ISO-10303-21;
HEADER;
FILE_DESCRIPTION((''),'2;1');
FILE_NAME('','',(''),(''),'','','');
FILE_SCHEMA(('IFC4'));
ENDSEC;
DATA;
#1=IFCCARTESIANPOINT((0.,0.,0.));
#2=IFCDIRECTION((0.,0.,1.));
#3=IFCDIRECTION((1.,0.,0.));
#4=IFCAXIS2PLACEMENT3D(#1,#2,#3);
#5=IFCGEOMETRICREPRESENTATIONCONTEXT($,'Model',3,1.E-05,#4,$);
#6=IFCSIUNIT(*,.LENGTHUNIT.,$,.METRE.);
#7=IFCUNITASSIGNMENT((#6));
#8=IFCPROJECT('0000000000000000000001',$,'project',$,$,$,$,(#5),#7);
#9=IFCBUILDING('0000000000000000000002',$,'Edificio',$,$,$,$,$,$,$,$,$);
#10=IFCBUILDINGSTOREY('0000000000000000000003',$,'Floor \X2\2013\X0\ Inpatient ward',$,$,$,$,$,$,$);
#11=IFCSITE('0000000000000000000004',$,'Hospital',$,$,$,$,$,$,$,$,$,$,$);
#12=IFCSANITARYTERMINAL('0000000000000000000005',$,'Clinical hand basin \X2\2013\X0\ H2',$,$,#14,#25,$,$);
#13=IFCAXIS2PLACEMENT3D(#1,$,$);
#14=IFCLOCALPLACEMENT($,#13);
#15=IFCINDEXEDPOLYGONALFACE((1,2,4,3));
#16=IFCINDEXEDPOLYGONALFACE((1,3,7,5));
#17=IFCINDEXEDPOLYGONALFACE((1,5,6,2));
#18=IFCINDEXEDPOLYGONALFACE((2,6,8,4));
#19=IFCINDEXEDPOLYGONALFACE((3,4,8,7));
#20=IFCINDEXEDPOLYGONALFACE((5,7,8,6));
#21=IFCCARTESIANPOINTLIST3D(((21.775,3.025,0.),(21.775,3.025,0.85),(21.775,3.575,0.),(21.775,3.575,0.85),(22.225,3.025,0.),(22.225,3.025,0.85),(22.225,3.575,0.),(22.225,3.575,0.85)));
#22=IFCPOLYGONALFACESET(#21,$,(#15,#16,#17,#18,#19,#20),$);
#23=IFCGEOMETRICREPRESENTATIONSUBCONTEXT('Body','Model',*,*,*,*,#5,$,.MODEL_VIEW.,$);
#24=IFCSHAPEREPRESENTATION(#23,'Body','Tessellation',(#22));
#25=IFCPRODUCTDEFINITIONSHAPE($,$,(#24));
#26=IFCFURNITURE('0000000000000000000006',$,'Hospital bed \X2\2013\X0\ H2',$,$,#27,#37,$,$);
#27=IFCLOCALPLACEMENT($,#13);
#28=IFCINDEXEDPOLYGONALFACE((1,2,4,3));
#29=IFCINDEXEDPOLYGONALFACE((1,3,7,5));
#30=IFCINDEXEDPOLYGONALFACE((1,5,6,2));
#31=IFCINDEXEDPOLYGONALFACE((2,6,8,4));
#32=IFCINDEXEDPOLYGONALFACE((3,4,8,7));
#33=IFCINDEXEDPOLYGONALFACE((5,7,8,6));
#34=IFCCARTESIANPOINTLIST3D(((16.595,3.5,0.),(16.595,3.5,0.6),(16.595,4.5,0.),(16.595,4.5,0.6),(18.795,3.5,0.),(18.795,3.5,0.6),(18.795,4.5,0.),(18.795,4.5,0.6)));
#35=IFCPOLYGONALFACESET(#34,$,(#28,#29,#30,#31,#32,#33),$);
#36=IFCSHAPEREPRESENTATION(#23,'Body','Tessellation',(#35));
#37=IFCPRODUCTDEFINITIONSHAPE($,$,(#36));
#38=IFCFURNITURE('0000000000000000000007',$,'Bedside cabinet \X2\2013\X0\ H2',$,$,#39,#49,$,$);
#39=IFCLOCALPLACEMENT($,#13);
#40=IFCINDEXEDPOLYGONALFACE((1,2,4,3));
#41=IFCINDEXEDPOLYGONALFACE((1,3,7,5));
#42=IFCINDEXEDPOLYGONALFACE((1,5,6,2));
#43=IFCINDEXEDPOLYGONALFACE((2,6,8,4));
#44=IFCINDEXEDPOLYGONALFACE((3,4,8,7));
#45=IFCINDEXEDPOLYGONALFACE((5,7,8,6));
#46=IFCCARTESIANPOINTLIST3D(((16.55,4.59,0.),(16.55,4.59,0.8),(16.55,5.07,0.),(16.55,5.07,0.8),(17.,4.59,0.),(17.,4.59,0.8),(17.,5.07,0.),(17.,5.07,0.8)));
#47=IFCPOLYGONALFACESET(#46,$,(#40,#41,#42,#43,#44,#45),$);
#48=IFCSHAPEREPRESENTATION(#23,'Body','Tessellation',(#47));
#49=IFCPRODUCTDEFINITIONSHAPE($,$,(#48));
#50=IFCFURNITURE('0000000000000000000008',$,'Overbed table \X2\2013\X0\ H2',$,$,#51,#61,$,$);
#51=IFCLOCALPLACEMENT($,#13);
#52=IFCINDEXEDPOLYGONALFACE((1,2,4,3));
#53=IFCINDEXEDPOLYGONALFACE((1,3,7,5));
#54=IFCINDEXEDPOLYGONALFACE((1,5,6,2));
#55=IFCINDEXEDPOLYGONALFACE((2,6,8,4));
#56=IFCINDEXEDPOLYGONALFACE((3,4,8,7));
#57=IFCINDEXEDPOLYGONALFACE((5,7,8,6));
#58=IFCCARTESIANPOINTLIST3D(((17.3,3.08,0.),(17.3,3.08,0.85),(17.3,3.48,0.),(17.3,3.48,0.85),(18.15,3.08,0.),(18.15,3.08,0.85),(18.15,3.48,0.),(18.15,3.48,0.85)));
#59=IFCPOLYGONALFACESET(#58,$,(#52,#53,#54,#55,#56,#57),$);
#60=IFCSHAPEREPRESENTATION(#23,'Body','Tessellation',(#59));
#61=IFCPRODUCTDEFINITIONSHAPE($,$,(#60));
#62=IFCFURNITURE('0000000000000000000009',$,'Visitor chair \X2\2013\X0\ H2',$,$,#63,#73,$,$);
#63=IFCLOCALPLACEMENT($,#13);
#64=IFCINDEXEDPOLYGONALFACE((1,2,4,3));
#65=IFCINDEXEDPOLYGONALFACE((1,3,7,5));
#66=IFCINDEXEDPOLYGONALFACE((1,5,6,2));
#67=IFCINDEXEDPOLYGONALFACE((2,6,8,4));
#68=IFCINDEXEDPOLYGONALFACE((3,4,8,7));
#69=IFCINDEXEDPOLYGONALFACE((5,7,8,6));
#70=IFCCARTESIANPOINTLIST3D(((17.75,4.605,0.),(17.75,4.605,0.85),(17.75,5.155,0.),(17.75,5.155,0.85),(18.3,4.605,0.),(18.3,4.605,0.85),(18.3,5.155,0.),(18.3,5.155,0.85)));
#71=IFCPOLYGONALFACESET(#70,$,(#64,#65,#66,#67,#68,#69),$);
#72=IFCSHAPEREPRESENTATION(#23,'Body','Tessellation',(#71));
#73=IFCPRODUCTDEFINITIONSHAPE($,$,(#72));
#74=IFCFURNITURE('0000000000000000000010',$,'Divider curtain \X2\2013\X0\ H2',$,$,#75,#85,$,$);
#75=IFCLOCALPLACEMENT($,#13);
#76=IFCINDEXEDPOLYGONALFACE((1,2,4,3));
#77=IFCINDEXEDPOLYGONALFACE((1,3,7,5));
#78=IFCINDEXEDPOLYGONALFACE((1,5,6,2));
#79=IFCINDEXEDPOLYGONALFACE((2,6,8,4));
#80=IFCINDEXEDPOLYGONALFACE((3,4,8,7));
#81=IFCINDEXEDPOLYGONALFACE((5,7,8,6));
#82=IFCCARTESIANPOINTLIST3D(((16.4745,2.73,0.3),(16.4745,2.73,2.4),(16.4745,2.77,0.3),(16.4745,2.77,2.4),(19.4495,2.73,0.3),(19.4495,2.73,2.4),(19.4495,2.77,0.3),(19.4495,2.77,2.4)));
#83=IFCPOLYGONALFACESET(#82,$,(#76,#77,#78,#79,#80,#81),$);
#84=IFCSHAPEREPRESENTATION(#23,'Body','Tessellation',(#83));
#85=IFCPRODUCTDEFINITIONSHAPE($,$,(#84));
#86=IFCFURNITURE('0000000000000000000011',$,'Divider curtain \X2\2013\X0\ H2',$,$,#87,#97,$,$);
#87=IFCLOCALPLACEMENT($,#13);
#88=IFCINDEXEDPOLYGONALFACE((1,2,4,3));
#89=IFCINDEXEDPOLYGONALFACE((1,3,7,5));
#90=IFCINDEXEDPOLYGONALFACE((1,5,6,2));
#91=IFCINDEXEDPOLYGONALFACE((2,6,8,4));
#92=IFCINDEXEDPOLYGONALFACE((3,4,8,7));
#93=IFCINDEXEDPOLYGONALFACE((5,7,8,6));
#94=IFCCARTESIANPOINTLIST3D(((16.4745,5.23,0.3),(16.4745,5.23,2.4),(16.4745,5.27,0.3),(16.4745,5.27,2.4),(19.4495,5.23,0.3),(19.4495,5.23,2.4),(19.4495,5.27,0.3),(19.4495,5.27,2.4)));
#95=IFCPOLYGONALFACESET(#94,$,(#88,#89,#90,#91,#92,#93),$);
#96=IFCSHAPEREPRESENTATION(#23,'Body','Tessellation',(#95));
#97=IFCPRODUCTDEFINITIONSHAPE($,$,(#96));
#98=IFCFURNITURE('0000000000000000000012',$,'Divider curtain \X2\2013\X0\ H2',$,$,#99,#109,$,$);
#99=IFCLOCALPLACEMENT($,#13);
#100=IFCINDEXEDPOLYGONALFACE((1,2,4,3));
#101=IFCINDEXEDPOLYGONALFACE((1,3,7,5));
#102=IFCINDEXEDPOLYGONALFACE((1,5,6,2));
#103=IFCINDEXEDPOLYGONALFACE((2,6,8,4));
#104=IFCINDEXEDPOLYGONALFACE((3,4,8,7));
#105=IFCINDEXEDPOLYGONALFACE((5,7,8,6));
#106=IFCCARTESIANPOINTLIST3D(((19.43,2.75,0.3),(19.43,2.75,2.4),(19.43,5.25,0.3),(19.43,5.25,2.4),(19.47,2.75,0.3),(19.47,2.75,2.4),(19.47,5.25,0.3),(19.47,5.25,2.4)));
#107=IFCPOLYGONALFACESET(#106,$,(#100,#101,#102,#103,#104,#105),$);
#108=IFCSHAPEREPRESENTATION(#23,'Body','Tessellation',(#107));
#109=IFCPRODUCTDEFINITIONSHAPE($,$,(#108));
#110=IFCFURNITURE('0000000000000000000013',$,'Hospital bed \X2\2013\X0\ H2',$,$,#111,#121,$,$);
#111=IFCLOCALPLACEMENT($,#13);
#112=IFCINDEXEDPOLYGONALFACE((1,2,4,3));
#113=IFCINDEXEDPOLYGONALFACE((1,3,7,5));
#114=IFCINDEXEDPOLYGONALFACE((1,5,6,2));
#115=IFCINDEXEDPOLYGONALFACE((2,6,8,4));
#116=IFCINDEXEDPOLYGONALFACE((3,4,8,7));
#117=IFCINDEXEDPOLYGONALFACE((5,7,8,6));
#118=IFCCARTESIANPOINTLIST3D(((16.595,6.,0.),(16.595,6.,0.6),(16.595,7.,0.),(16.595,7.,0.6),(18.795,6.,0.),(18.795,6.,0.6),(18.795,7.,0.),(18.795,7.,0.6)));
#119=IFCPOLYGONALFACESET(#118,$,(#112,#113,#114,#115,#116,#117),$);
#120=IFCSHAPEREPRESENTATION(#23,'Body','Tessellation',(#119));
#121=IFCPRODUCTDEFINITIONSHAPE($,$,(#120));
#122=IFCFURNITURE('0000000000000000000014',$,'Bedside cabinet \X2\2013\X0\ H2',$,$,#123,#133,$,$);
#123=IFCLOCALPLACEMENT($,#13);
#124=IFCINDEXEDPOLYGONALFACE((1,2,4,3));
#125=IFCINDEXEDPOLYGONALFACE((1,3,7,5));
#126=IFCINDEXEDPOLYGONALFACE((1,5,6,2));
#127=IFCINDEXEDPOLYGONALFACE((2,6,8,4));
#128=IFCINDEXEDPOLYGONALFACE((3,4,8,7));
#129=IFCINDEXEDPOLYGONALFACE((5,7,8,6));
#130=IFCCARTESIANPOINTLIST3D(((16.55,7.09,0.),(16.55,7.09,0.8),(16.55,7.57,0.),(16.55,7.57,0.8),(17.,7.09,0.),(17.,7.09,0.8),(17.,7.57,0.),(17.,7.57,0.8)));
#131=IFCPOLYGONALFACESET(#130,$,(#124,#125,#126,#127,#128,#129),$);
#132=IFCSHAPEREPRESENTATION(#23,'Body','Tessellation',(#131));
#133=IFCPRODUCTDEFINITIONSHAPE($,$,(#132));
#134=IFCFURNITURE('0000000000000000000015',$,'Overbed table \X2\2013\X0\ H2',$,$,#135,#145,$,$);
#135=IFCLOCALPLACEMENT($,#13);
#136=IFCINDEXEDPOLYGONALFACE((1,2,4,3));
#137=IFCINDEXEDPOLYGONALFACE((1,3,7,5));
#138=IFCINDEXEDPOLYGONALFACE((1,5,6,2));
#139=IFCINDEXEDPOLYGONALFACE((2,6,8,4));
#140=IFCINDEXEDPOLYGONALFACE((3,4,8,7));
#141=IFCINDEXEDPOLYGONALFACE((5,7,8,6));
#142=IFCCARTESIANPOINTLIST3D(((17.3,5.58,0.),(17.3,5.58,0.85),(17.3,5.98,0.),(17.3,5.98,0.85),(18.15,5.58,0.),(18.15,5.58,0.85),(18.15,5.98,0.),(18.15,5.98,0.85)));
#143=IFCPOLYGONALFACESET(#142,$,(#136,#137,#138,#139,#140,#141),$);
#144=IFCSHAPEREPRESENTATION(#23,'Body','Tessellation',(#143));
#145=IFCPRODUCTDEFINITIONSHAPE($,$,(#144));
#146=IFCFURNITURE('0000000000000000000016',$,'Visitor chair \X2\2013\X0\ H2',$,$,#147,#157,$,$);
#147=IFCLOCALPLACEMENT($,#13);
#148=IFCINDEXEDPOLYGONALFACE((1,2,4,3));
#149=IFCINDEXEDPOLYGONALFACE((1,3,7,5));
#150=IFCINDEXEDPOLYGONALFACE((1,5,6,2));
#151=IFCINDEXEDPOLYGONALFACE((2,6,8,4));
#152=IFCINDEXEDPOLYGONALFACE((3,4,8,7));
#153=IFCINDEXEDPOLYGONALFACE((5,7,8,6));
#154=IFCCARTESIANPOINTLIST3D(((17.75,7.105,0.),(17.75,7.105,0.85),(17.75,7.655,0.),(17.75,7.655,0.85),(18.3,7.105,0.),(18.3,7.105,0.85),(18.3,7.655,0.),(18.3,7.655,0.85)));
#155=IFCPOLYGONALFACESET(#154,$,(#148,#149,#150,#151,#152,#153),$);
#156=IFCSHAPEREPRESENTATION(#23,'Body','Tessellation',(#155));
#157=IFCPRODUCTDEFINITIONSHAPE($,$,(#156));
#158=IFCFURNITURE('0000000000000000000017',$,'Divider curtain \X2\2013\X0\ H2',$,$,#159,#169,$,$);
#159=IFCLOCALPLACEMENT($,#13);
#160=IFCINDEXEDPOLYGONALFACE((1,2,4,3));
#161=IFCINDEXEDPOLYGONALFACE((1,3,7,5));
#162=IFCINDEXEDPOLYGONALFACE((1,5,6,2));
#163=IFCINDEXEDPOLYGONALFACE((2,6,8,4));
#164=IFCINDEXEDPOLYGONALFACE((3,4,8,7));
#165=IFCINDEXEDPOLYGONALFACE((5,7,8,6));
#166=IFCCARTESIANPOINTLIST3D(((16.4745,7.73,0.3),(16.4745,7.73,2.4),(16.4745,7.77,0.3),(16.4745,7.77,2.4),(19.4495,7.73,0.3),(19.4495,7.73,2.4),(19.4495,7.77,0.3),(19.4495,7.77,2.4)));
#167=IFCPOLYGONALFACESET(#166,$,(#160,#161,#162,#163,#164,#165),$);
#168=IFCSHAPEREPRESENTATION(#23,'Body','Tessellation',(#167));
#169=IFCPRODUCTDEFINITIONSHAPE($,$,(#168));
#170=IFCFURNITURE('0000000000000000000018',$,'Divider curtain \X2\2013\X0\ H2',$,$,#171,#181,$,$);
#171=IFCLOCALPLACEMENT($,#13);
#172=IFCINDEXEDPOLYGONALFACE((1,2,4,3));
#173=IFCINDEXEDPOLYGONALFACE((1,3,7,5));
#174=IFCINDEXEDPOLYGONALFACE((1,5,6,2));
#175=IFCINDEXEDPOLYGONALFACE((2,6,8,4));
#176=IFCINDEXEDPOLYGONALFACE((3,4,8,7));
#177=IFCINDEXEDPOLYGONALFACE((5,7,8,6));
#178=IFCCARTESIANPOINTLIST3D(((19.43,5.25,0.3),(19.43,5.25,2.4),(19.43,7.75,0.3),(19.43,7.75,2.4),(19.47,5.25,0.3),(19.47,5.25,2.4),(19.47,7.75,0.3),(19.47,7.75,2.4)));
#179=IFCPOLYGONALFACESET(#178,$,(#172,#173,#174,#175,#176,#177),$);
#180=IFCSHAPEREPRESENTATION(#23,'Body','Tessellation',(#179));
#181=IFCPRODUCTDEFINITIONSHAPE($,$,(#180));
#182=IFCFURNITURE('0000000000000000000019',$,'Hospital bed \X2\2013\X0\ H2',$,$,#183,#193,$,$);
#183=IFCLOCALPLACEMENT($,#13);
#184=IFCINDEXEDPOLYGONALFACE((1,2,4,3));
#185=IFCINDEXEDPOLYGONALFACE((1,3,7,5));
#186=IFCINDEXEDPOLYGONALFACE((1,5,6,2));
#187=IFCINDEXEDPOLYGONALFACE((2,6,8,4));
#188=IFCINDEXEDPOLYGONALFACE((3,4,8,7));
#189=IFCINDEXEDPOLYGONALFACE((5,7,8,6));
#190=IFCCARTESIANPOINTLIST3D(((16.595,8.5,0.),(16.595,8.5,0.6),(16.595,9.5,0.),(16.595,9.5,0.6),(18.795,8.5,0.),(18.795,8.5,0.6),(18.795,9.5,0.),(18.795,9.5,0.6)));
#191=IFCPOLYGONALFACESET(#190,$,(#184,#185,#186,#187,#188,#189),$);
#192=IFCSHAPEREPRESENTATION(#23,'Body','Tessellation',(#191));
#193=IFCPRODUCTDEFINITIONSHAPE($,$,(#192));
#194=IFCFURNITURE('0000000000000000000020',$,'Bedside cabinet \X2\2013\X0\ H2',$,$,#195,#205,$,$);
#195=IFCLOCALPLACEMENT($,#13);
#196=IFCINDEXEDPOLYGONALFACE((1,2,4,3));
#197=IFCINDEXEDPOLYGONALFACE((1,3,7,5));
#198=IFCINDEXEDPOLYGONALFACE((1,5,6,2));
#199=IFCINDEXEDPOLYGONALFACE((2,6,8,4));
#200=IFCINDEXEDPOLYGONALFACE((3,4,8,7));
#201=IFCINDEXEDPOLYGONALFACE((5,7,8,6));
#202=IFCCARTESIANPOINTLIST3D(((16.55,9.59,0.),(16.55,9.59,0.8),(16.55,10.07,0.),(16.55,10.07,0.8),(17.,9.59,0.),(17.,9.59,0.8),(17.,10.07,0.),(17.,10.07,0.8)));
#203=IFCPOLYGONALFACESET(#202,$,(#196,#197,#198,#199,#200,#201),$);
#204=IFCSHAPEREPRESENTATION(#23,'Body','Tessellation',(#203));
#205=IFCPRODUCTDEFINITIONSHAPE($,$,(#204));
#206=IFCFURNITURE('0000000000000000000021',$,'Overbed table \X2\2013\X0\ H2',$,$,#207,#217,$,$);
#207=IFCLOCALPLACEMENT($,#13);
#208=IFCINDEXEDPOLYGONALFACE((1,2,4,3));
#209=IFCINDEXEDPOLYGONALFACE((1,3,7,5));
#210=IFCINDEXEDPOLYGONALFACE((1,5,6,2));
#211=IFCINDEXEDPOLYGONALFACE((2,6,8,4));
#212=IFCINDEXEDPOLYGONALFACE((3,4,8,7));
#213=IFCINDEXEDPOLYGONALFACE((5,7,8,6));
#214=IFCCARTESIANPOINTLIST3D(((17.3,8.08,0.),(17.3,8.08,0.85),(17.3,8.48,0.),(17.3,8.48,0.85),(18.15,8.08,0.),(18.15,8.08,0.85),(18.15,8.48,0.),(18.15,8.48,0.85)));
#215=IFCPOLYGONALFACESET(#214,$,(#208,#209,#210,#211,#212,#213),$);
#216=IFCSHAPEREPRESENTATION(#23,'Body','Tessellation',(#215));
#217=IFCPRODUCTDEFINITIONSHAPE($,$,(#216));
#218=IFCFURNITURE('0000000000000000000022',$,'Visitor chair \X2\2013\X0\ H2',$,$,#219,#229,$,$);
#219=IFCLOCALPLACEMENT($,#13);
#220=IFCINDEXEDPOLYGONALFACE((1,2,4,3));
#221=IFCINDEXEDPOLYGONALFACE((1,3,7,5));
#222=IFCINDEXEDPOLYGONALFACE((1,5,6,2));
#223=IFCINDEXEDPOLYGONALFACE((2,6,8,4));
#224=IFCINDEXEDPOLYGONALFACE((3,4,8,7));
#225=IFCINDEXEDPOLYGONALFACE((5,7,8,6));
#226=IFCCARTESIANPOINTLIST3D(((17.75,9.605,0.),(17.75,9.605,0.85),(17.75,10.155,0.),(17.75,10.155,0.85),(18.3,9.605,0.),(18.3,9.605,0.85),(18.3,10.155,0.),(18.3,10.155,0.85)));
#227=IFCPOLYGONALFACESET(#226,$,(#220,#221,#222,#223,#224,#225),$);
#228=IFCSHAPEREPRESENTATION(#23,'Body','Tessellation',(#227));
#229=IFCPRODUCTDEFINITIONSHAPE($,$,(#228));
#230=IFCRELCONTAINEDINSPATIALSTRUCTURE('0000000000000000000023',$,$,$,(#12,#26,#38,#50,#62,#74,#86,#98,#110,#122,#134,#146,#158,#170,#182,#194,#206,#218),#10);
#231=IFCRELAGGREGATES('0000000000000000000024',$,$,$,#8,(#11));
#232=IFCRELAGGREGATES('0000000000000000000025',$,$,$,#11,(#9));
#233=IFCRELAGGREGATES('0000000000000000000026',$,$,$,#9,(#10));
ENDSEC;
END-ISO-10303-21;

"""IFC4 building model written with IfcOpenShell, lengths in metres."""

from ifc_helpers import new_model, si_unit, frame, origin_with_axes, context, subcontext, project, spatial, line, indexed_curve, outline, extrude, element, save


model = new_model("IFC4")

# Units and contexts
model_context = context("Model", 3, precision=1e-05, world=origin_with_axes())
body_context = subcontext(model_context, "Body", "Model", "MODEL_VIEW")
ifc_project = project(units=[si_unit("LENGTHUNIT", "METRE")], contexts=[model_context])

# Site, building, storey
site = spatial("IfcSite", under=ifc_project, Name="Hospital")
building = spatial("IfcBuilding", under=site, Name="Edificio")
storey = spatial("IfcBuildingStorey", under=building, Name="Floor – Inpatient ward")

# Sanitary terminal
element("IfcSanitaryTerminal", 1, inside=storey, Name="Clinical hand basin – H2", context=body_context, shape_type="SweptSolid", body=[
    extrude(outline(indexed_curve([(0.0, 0.0), (0.45, 0.0), (0.45, 0.55), (0.0, 0.55)], segments=[line(1, 2, 3, 4, 1)])), frame((21.775, 3.025, 0.0), z_axis=(0.0, 0.0, 1.0), x_axis=(1.0, 0.0, 0.0)), (0.0, 0.0, 1.0), 0.85),
])

# Furniture
element("IfcFurniture", 2, inside=storey, Name="Hospital bed – H2", context=body_context, shape_type="SweptSolid", body=[
    extrude(outline(indexed_curve([(0.0, 0.0), (2.2, 0.0), (2.2, 1.0), (0.0, 1.0)], segments=[line(1, 2, 3, 4, 1)])), frame((16.595, 3.5, 0.0), z_axis=(0.0, 0.0, 1.0), x_axis=(1.0, 0.0, 0.0)), (0.0, 0.0, 1.0), 0.6),
])
element("IfcFurniture", 3, inside=storey, Name="Bedside cabinet – H2", context=body_context, shape_type="SweptSolid", body=[
    extrude(outline(indexed_curve([(0.0, 0.0), (0.45, 0.0), (0.45, 0.48), (0.0, 0.48)], segments=[line(1, 2, 3, 4, 1)])), frame((16.55, 4.59, 0.0), z_axis=(0.0, 0.0, 1.0), x_axis=(1.0, 0.0, 0.0)), (0.0, 0.0, 1.0), 0.8),
])
element("IfcFurniture", 4, inside=storey, Name="Overbed table – H2", context=body_context, shape_type="SweptSolid", body=[
    extrude(outline(indexed_curve([(0.0, 0.0), (0.85, 0.0), (0.85, 0.4), (0.0, 0.4)], segments=[line(1, 2, 3, 4, 1)])), frame((17.3, 3.08, 0.0), z_axis=(0.0, 0.0, 1.0), x_axis=(1.0, 0.0, 0.0)), (0.0, 0.0, 1.0), 0.85),
])
element("IfcFurniture", 5, inside=storey, Name="Visitor chair – H2", context=body_context, shape_type="SweptSolid", body=[
    extrude(outline(indexed_curve([(0.0, 0.0), (0.55, 0.0), (0.55, 0.55), (0.0, 0.55)], segments=[line(1, 2, 3, 4, 1)])), frame((17.75, 4.605, 0.0), z_axis=(0.0, 0.0, 1.0), x_axis=(1.0, 0.0, 0.0)), (0.0, 0.0, 1.0), 0.85),
])
element("IfcFurniture", 6, inside=storey, Name="Divider curtain – H2", context=body_context, shape_type="SweptSolid", body=[
    extrude(outline(indexed_curve([(0.0, 0.0), (2.975, 0.0), (2.975, 0.04), (0.0, 0.04)], segments=[line(1, 2, 3, 4, 1)])), frame((16.4745, 2.73, 0.3), z_axis=(0.0, 0.0, 1.0), x_axis=(1.0, 0.0, 0.0)), (0.0, 0.0, 1.0), 2.1),
])
element("IfcFurniture", 7, inside=storey, Name="Divider curtain – H2", context=body_context, shape_type="SweptSolid", body=[
    extrude(outline(indexed_curve([(0.0, 0.0), (2.975, 0.0), (2.975, 0.04), (0.0, 0.04)], segments=[line(1, 2, 3, 4, 1)])), frame((16.4745, 5.23, 0.3), z_axis=(0.0, 0.0, 1.0), x_axis=(1.0, 0.0, 0.0)), (0.0, 0.0, 1.0), 2.1),
])
element("IfcFurniture", 8, inside=storey, Name="Divider curtain – H2", context=body_context, shape_type="SweptSolid", body=[
    extrude(outline(indexed_curve([(0.0, 0.0), (0.04, 0.0), (0.04, 2.5), (0.0, 2.5)], segments=[line(1, 2, 3, 4, 1)])), frame((19.43, 2.75, 0.3), z_axis=(0.0, 0.0, 1.0), x_axis=(1.0, 0.0, 0.0)), (0.0, 0.0, 1.0), 2.1),
])
element("IfcFurniture", 9, inside=storey, Name="Hospital bed – H2", context=body_context, shape_type="SweptSolid", body=[
    extrude(outline(indexed_curve([(0.0, 0.0), (2.2, 0.0), (2.2, 1.0), (0.0, 1.0)], segments=[line(1, 2, 3, 4, 1)])), frame((16.595, 6.0, 0.0), z_axis=(0.0, 0.0, 1.0), x_axis=(1.0, 0.0, 0.0)), (0.0, 0.0, 1.0), 0.6),
])
element("IfcFurniture", 10, inside=storey, Name="Bedside cabinet – H2", context=body_context, shape_type="SweptSolid", body=[
    extrude(outline(indexed_curve([(0.0, 0.0), (0.45, 0.0), (0.45, 0.48), (0.0, 0.48)], segments=[line(1, 2, 3, 4, 1)])), frame((16.55, 7.09, 0.0), z_axis=(0.0, 0.0, 1.0), x_axis=(1.0, 0.0, 0.0)), (0.0, 0.0, 1.0), 0.8),
])
element("IfcFurniture", 11, inside=storey, Name="Overbed table – H2", context=body_context, shape_type="SweptSolid", body=[
    extrude(outline(indexed_curve([(0.0, 0.0), (0.85, 0.0), (0.85, 0.4), (0.0, 0.4)], segments=[line(1, 2, 3, 4, 1)])), frame((17.3, 5.58, 0.0), z_axis=(0.0, 0.0, 1.0), x_axis=(1.0, 0.0, 0.0)), (0.0, 0.0, 1.0), 0.85),
])
element("IfcFurniture", 12, inside=storey, Name="Visitor chair – H2", context=body_context, shape_type="SweptSolid", body=[
    extrude(outline(indexed_curve([(0.0, 0.0), (0.55, 0.0), (0.55, 0.55), (0.0, 0.55)], segments=[line(1, 2, 3, 4, 1)])), frame((17.75, 7.105, 0.0), z_axis=(0.0, 0.0, 1.0), x_axis=(1.0, 0.0, 0.0)), (0.0, 0.0, 1.0), 0.85),
])
element("IfcFurniture", 13, inside=storey, Name="Divider curtain – H2", context=body_context, shape_type="SweptSolid", body=[
    extrude(outline(indexed_curve([(0.0, 0.0), (2.975, 0.0), (2.975, 0.04), (0.0, 0.04)], segments=[line(1, 2, 3, 4, 1)])), frame((16.4745, 7.73, 0.3), z_axis=(0.0, 0.0, 1.0), x_axis=(1.0, 0.0, 0.0)), (0.0, 0.0, 1.0), 2.1),
])
element("IfcFurniture", 14, inside=storey, Name="Divider curtain – H2", context=body_context, shape_type="SweptSolid", body=[
    extrude(outline(indexed_curve([(0.0, 0.0), (0.04, 0.0), (0.04, 2.5), (0.0, 2.5)], segments=[line(1, 2, 3, 4, 1)])), frame((19.43, 5.25, 0.3), z_axis=(0.0, 0.0, 1.0), x_axis=(1.0, 0.0, 0.0)), (0.0, 0.0, 1.0), 2.1),
])
element("IfcFurniture", 15, inside=storey, Name="Hospital bed – H2", context=body_context, shape_type="SweptSolid", body=[
    extrude(outline(indexed_curve([(0.0, 0.0), (2.2, 0.0), (2.2, 1.0), (0.0, 1.0)], segments=[line(1, 2, 3, 4, 1)])), frame((16.595, 8.5, 0.0), z_axis=(0.0, 0.0, 1.0), x_axis=(1.0, 0.0, 0.0)), (0.0, 0.0, 1.0), 0.6),
])
element("IfcFurniture", 16, inside=storey, Name="Bedside cabinet – H2", context=body_context, shape_type="SweptSolid", body=[
    extrude(outline(indexed_curve([(0.0, 0.0), (0.45, 0.0), (0.45, 0.48), (0.0, 0.48)], segments=[line(1, 2, 3, 4, 1)])), frame((16.55, 9.59, 0.0), z_axis=(0.0, 0.0, 1.0), x_axis=(1.0, 0.0, 0.0)), (0.0, 0.0, 1.0), 0.8),
])
element("IfcFurniture", 17, inside=storey, Name="Overbed table – H2", context=body_context, shape_type="SweptSolid", body=[
    extrude(outline(indexed_curve([(0.0, 0.0), (0.85, 0.0), (0.85, 0.4), (0.0, 0.4)], segments=[line(1, 2, 3, 4, 1)])), frame((17.3, 8.08, 0.0), z_axis=(0.0, 0.0, 1.0), x_axis=(1.0, 0.0, 0.0)), (0.0, 0.0, 1.0), 0.85),
])
element("IfcFurniture", 18, inside=storey, Name="Visitor chair – H2", context=body_context, shape_type="SweptSolid", body=[
    extrude(outline(indexed_curve([(0.0, 0.0), (0.55, 0.0), (0.55, 0.55), (0.0, 0.55)], segments=[line(1, 2, 3, 4, 1)])), frame((17.75, 9.605, 0.0), z_axis=(0.0, 0.0, 1.0), x_axis=(1.0, 0.0, 0.0)), (0.0, 0.0, 1.0), 0.85),
])

save(model, "model.ifc")
